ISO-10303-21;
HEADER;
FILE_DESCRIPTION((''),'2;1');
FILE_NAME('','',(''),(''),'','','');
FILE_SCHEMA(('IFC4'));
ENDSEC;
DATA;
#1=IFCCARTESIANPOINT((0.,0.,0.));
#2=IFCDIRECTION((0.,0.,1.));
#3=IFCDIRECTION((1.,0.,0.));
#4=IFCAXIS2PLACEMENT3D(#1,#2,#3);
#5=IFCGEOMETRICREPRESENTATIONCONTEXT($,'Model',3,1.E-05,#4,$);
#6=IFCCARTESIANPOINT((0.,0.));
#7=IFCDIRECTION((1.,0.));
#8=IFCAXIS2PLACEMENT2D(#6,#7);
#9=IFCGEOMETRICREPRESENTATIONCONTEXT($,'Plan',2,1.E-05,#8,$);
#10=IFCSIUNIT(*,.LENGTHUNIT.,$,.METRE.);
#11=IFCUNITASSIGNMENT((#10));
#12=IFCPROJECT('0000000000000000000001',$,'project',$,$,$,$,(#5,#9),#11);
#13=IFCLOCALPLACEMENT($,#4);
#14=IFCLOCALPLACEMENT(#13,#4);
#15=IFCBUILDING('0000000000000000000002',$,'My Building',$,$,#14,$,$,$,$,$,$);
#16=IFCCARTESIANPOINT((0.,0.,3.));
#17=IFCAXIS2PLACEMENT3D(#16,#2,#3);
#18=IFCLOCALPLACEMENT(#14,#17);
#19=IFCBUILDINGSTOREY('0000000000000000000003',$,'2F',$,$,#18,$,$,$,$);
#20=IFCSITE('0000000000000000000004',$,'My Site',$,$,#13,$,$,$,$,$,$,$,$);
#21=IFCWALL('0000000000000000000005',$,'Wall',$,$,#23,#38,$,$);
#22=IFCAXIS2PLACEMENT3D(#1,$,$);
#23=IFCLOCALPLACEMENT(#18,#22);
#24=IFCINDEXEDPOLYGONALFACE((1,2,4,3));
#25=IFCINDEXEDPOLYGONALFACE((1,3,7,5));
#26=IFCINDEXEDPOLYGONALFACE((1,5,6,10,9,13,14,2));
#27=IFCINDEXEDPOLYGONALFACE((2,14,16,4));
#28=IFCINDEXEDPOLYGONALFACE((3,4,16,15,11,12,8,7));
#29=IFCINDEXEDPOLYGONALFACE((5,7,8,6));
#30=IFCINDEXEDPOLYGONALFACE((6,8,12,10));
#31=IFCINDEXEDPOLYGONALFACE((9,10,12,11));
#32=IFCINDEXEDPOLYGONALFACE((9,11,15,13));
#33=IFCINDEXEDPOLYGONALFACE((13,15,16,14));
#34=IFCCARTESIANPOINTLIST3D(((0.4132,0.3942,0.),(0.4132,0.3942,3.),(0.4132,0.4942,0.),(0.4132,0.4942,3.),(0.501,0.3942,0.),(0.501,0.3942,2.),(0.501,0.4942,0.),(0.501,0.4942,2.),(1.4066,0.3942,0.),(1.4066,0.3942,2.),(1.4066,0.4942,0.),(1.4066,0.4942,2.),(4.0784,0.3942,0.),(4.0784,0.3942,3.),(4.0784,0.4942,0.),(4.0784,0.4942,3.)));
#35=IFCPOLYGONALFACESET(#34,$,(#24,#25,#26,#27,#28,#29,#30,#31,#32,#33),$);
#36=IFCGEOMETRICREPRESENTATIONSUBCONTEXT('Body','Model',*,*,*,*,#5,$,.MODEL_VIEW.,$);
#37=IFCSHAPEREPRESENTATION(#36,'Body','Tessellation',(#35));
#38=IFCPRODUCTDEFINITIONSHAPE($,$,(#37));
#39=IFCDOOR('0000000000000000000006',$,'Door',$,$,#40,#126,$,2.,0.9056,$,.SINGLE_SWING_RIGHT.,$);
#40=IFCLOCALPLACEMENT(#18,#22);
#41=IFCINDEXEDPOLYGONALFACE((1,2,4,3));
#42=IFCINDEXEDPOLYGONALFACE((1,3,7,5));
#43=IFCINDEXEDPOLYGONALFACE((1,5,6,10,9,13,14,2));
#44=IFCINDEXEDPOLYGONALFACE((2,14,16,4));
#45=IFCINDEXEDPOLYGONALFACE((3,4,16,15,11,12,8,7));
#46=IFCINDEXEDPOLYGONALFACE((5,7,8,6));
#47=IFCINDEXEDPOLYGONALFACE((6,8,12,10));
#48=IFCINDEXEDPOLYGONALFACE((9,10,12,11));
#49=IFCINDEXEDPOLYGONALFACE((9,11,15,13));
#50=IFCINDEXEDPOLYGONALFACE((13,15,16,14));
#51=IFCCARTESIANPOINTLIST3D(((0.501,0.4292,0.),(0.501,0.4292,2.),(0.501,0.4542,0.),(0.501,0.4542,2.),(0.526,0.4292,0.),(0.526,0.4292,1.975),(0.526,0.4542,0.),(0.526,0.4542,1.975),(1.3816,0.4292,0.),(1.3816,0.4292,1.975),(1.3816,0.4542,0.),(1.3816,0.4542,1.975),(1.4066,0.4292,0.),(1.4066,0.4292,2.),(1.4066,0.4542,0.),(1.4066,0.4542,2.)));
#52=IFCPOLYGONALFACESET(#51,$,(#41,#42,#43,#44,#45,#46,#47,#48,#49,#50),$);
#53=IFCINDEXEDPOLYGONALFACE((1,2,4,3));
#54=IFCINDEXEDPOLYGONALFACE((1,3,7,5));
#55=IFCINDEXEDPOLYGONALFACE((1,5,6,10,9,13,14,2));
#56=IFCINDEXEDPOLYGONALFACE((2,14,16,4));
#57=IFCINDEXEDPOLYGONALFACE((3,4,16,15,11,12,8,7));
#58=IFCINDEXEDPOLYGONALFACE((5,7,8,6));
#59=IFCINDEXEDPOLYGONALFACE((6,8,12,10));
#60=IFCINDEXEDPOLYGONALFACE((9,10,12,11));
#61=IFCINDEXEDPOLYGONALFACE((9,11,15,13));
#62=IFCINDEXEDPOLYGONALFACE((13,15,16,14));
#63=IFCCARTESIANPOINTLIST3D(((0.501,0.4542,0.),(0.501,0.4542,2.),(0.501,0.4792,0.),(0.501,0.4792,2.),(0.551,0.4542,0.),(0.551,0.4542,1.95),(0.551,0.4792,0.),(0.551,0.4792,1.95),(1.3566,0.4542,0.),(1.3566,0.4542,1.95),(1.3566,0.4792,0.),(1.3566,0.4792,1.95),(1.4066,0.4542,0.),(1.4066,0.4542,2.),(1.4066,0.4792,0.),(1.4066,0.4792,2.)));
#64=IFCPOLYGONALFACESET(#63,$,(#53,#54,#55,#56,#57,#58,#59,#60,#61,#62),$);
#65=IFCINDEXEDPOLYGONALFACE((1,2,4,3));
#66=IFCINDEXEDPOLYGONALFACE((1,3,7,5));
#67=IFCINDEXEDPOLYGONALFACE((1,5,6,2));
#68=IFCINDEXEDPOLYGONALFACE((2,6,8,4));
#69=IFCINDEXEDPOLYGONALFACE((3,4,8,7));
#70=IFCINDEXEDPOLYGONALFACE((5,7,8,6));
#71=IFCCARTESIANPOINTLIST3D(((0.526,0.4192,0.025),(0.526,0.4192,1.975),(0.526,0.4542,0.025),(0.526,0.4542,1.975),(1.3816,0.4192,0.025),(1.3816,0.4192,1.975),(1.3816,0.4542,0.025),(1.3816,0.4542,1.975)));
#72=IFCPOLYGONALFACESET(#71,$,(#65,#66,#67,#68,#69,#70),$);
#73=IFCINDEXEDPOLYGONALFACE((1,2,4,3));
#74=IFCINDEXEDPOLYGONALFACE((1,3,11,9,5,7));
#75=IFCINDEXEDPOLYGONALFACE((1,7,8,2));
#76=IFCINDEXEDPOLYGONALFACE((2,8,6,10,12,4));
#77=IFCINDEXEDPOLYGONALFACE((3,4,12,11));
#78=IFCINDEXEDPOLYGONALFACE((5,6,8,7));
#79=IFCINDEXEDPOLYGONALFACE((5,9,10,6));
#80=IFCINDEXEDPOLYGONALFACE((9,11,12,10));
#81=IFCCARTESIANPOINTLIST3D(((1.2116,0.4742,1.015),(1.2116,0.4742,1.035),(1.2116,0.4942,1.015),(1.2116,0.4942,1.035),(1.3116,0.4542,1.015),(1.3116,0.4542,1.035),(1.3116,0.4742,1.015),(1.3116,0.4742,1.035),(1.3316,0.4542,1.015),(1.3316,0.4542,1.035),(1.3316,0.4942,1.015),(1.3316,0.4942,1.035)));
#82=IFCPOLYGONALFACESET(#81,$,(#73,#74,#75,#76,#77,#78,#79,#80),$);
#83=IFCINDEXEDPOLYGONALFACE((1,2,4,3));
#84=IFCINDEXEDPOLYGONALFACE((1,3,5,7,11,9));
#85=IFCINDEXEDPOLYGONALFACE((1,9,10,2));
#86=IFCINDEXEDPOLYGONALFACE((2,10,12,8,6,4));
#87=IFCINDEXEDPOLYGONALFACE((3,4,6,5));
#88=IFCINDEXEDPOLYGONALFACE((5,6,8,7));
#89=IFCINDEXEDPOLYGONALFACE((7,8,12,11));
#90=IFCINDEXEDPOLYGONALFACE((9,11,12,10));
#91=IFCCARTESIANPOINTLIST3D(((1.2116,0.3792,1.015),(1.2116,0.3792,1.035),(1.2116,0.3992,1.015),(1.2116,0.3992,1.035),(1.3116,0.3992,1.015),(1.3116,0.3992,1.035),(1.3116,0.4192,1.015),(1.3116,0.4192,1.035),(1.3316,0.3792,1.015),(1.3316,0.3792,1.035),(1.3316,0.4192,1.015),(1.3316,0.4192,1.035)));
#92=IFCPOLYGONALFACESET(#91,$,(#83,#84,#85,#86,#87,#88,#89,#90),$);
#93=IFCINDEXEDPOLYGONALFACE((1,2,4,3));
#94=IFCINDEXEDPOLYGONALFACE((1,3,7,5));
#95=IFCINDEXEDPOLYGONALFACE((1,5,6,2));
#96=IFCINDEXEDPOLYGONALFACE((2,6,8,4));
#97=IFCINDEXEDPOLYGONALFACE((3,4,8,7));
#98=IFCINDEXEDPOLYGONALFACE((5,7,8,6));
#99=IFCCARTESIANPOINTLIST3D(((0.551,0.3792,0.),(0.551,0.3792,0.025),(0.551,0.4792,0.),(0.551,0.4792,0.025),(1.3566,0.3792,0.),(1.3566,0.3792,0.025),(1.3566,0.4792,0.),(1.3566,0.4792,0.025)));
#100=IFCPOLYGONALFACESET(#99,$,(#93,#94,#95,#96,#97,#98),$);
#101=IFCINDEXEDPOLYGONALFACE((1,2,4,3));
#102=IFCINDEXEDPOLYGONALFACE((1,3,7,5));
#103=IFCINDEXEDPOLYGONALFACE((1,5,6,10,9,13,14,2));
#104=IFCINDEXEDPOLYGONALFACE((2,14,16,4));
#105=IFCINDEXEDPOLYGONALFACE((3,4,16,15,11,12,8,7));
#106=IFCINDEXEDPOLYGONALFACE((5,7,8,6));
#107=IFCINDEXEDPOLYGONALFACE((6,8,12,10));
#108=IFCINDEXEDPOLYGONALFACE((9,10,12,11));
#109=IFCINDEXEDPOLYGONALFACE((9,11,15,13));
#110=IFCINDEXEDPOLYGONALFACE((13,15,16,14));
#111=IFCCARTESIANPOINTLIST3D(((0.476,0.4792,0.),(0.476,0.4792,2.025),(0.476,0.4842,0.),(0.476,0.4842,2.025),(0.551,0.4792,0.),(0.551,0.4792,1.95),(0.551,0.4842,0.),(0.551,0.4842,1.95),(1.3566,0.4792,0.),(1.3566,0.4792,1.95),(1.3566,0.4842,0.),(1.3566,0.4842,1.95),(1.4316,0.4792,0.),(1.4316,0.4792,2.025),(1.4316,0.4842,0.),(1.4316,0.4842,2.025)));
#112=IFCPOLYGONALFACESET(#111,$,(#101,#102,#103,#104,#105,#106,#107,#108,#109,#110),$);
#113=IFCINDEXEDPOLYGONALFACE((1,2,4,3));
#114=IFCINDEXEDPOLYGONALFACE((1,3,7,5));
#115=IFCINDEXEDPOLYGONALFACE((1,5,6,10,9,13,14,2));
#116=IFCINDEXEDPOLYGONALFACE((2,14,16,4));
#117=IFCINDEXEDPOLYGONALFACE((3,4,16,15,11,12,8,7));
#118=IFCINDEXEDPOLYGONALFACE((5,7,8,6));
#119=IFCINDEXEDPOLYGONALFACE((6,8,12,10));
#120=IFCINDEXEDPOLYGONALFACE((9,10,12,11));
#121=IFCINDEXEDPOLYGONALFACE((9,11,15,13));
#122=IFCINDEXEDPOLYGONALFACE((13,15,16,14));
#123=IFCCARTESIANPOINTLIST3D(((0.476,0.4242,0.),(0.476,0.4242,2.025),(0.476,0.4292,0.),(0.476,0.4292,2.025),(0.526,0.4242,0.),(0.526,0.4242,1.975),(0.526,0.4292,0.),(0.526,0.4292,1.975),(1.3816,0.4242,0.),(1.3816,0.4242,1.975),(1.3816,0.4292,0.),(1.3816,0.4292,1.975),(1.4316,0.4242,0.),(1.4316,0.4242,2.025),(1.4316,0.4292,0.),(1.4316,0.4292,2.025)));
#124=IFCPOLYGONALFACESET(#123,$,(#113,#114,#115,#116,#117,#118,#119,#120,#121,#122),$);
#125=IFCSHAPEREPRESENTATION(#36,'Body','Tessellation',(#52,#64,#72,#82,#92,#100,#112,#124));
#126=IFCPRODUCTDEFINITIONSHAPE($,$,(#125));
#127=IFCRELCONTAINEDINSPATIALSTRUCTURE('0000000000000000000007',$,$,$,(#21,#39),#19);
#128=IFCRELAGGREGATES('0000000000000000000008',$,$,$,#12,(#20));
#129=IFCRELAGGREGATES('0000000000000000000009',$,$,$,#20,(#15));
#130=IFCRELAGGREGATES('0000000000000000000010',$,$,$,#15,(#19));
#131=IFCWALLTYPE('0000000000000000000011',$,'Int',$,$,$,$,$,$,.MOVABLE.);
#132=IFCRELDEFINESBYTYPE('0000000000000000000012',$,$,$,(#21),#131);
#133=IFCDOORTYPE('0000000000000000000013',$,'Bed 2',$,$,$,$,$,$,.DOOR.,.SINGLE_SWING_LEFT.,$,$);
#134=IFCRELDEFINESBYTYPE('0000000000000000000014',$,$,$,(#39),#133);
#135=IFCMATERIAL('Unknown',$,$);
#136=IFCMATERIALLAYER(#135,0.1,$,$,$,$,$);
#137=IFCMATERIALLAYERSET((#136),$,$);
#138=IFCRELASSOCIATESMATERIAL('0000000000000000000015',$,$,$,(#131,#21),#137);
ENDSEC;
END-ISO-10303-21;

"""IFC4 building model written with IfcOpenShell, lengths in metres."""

from ifc_helpers import new_model, entity, si_unit, frame, origin_with_axes, origin_2d_with_axis, place, context, subcontext, project, spatial, line, indexed_curve, outline, extrude, shape, source, transform, mapped, material, layer, layer_set, layer_usage, type_object, type_shapes, element, fill, save


model = new_model("IFC4")

# Units and contexts
model_context = context("Model", 3, precision=1e-05, world=origin_with_axes())
plan_context = context("Plan", 2, precision=1e-05, world=origin_2d_with_axis())
body_context_1 = subcontext(model_context, "Body", "Model", "MODEL_VIEW")
body_context_2 = subcontext(plan_context, "Body", "Plan", "PLAN_VIEW")
ifc_project = project(units=[si_unit("LENGTHUNIT", "METRE")], contexts=[model_context, plan_context])

# Site, building, storey
site_placement = place(None, origin_with_axes())
site = spatial("IfcSite", under=ifc_project, at=site_placement, Name="My Site")
building_placement = place(site_placement, origin_with_axes())
building = spatial("IfcBuilding", under=site, at=building_placement, Name="My Building")
storey_placement = place(building_placement, frame((0.0, 0.0, 3.0), z_axis=(0.0, 0.0, 1.0), x_axis=(1.0, 0.0, 0.0)))
storey = spatial("IfcBuildingStorey", under=building, at=storey_placement, Name="2F")

# Shared definitions
ifc_material = material(Name="Unknown")

# Shared definitions
ifc_layer_1 = layer(ifc_material, 0.1)
ifc_layer_set_1 = layer_set([ifc_layer_1])
wall_type_1 = type_object("IfcWallType", Name="Int", PredefinedType="MOVABLE", material=ifc_layer_set_1)

# Wall, opening, door
ifc_layer_usage_1 = layer_usage(ifc_layer_set_1, "AXIS2", "POSITIVE", 0.0)
wall_1_placement = place(storey_placement, frame((0.4132, 0.3942, 0.0), z_axis=(0.0, 0.0, 1.0), x_axis=(1.0, 0.0, 0.0)))
wall_1 = element("IfcWall", 1, at=wall_1_placement, inside=storey, type_object=wall_type_1, material=ifc_layer_usage_1, Name="Wall", context=body_context_1, shape_type="SweptSolid", body=[
    extrude(outline(indexed_curve([(0.0, 0.0), (0.0, 0.1), (3.6652, 0.1), (3.6652, 0.0)], segments=[line(1, 2, 3, 4, 1)])), origin_with_axes(), (0.0, 0.0, 1.0), 3.0),
])
shared_shape_1 = source(origin_with_axes(), body_context_1, "Body", "SweptSolid", [
    extrude(outline(indexed_curve([(0.0, 0.0), (0.9056, 0.0), (0.9056, 2.0), (0.0, 2.0)], segments=[line(1, 2, 3, 4, 1)])), frame((0.0, -0.6, 0.0), z_axis=(0.0, -1.0, 0.0), x_axis=(1.0, 0.0, 0.0)), (0.0, 0.0, -1.0), 1.2),
])
opening_1_placement = place(wall_1_placement, frame((0.9934, 0.085, 0.0), z_axis=(0.0, 0.0, 1.0), x_axis=(-1.0, 0.0, 0.0)))
opening_1 = element("IfcOpeningElement", 2, at=opening_1_placement, cuts=wall_1, PredefinedType="OPENING", context=body_context_1, shape_type="MappedRepresentation", body=[
    mapped(shared_shape_1, transform((0.0, 0.0, 0.0), x_axis=(1.0, 0.0, 0.0), y_axis=(0.0, 1.0, 0.0), z_axis=(0.0, 0.0, 1.0), scale=1.0)),
])
door_type_1 = type_object("IfcDoorType", Name="Bed 2", OperationType="SINGLE_SWING_LEFT", PredefinedType="DOOR")
shared_shape_2 = source(origin_with_axes(), body_context_1, "Body", "SweptSolid", [
    extrude(outline(indexed_curve([(0.0, 0.0), (0.0, 2.0), (0.9056, 2.0), (0.9056, 0.0), (0.8806, 0.0), (0.8806, 1.975), (0.025, 1.975), (0.025, 0.0)], segments=[line(1, 2, 3, 4, 5, 6, 7, 8, 1)])), frame((0.0, 0.025, 0.0), z_axis=(0.0, -1.0, 0.0), x_axis=(1.0, 0.0, 0.0)), (0.0, 0.0, -1.0), 0.025),
    extrude(outline(indexed_curve([(0.0, 0.0), (0.0, 2.0), (0.9056, 2.0), (0.9056, 0.0), (0.8556, 0.0), (0.8556, 1.95), (0.05, 1.95), (0.05, 0.0)], segments=[line(1, 2, 3, 4, 5, 6, 7, 8, 1)])), frame((0.0, 0.0, 0.0), z_axis=(0.0, -1.0, 0.0), x_axis=(1.0, 0.0, 0.0)), (0.0, 0.0, -1.0), 0.025),
    extrude(outline(indexed_curve([(0.0, 0.0), (0.8556, 0.0), (0.8556, 0.035), (0.0, 0.035)], segments=[line(1, 2, 3, 4, 1)])), frame((0.025, 0.025, 0.025), z_axis=(0.0, 0.0, 1.0), x_axis=(1.0, 0.0, 0.0)), (0.0, 0.0, 1.0), 1.95),
    extrude(outline(indexed_curve([(0.0, 0.0), (0.0, -0.04), (0.12, -0.04), (0.12, -0.02), (0.02, -0.02), (0.02, 0.0)], segments=[line(1, 2, 3, 4, 5, 6, 1)])), frame((0.075, 0.025, 1.015), z_axis=(0.0, 0.0, 1.0), x_axis=(1.0, 0.0, 0.0)), (0.0, 0.0, 1.0), 0.02),
    extrude(outline(indexed_curve([(0.0, 0.0), (0.0, 0.04), (0.12, 0.04), (0.12, 0.02), (0.02, 0.02), (0.02, 0.0)], segments=[line(1, 2, 3, 4, 5, 6, 1)])), frame((0.075, 0.06, 1.015), z_axis=(0.0, 0.0, 1.0), x_axis=(1.0, 0.0, 0.0)), (0.0, 0.0, 1.0), 0.02),
    extrude(outline(indexed_curve([(0.0, 0.0), (0.8056, 0.0), (0.8056, 0.1), (0.0, 0.1)], segments=[line(1, 2, 3, 4, 1)])), frame((0.05, 0.0, 0.0), z_axis=(0.0, 0.0, 1.0), x_axis=(1.0, 0.0, 0.0)), (0.0, 0.0, 1.0), 0.025),
    extrude(outline(indexed_curve([(0.0, 0.0), (0.0, 2.025), (0.9556, 2.025), (0.9556, 0.0), (0.8806, 0.0), (0.8806, 1.95), (0.075, 1.95), (0.075, 0.0)], segments=[line(1, 2, 3, 4, 5, 6, 7, 8, 1)])), frame((-0.025, -0.005, 0.0), z_axis=(0.0, -1.0, 0.0), x_axis=(1.0, 0.0, 0.0)), (0.0, 0.0, -1.0), 0.005),
    extrude(outline(indexed_curve([(0.0, 0.0), (0.0, 2.025), (0.9556, 2.025), (0.9556, 0.0), (0.9056, 0.0), (0.9056, 1.975), (0.05, 1.975), (0.05, 0.0)], segments=[line(1, 2, 3, 4, 5, 6, 7, 8, 1)])), frame((-0.025, 0.05, 0.0), z_axis=(0.0, -1.0, 0.0), x_axis=(1.0, 0.0, 0.0)), (0.0, 0.0, -1.0), 0.005),
])
shared_shape_3 = source(origin_with_axes(), body_context_2, "Body", "Curve2D", [
    entity("IfcIndexedPolyCurve", entity("IfcCartesianPointList2D", [[0.0, 0.0], [0.0, 0.05], [0.025, 0.05], [0.025, 0.025], [0.05, 0.025], [0.05, 0.0]]), [entity("IfcLineIndex", [1, 2, 3, 4, 5, 6, 1])]),
    entity("IfcIndexedPolyCurve", entity("IfcCartesianPointList2D", [[0.9056, 0.0], [0.9056, 0.05], [0.8806, 0.05], [0.8806, 0.025], [0.8556, 0.025], [0.8556, 0.0]]), [entity("IfcLineIndex", [1, 2, 3, 4, 5, 6, 1])]),
    entity("IfcTrimmedCurve", entity("IfcEllipse", entity("IfcAxis2Placement2D", entity("IfcCartesianPoint", [0.8456, 0.05]), entity("IfcDirection", [1.0, 0.0])), 0.8206, 0.8556), [entity("IfcCartesianPoint", [0.8456, 0.9056])], [entity("IfcCartesianPoint", [0.025, 0.05])], True, "CARTESIAN"),
    entity("IfcIndexedPolyCurve", entity("IfcCartesianPointList2D", [[0.8806, 0.05], [0.8456, 0.05], [0.8456, 0.9056], [0.8806, 0.9056]]), [entity("IfcLineIndex", [1, 2, 3, 4, 1])]),
])
type_shapes(door_type_1, [shared_shape_2, shared_shape_3])
door_1_placement = place(opening_1_placement, origin_with_axes())
door_1 = element("IfcDoor", 3, at=door_1_placement, inside=storey, type_object=door_type_1, Name="Door", OperationType="SINGLE_SWING_RIGHT", OverallHeight=2.0, OverallWidth=0.9056, shapes=[
    shape(body_context_1, "Body", "MappedRepresentation", [mapped(shared_shape_2, transform((0.0, 0.0, 0.0), x_axis=(1.0, 0.0, 0.0), y_axis=(0.0, 1.0, 0.0), z_axis=(0.0, 0.0, 1.0), scale=1.0))]),
    shape(body_context_2, "Body", "MappedRepresentation", [mapped(shared_shape_3, transform((0.0, 0.0, 0.0), x_axis=(1.0, 0.0, 0.0), y_axis=(0.0, 1.0, 0.0), z_axis=(0.0, 0.0, 1.0), scale=1.0))]),
])
fill(opening_1, door_1)

save(model, "model.ifc")
